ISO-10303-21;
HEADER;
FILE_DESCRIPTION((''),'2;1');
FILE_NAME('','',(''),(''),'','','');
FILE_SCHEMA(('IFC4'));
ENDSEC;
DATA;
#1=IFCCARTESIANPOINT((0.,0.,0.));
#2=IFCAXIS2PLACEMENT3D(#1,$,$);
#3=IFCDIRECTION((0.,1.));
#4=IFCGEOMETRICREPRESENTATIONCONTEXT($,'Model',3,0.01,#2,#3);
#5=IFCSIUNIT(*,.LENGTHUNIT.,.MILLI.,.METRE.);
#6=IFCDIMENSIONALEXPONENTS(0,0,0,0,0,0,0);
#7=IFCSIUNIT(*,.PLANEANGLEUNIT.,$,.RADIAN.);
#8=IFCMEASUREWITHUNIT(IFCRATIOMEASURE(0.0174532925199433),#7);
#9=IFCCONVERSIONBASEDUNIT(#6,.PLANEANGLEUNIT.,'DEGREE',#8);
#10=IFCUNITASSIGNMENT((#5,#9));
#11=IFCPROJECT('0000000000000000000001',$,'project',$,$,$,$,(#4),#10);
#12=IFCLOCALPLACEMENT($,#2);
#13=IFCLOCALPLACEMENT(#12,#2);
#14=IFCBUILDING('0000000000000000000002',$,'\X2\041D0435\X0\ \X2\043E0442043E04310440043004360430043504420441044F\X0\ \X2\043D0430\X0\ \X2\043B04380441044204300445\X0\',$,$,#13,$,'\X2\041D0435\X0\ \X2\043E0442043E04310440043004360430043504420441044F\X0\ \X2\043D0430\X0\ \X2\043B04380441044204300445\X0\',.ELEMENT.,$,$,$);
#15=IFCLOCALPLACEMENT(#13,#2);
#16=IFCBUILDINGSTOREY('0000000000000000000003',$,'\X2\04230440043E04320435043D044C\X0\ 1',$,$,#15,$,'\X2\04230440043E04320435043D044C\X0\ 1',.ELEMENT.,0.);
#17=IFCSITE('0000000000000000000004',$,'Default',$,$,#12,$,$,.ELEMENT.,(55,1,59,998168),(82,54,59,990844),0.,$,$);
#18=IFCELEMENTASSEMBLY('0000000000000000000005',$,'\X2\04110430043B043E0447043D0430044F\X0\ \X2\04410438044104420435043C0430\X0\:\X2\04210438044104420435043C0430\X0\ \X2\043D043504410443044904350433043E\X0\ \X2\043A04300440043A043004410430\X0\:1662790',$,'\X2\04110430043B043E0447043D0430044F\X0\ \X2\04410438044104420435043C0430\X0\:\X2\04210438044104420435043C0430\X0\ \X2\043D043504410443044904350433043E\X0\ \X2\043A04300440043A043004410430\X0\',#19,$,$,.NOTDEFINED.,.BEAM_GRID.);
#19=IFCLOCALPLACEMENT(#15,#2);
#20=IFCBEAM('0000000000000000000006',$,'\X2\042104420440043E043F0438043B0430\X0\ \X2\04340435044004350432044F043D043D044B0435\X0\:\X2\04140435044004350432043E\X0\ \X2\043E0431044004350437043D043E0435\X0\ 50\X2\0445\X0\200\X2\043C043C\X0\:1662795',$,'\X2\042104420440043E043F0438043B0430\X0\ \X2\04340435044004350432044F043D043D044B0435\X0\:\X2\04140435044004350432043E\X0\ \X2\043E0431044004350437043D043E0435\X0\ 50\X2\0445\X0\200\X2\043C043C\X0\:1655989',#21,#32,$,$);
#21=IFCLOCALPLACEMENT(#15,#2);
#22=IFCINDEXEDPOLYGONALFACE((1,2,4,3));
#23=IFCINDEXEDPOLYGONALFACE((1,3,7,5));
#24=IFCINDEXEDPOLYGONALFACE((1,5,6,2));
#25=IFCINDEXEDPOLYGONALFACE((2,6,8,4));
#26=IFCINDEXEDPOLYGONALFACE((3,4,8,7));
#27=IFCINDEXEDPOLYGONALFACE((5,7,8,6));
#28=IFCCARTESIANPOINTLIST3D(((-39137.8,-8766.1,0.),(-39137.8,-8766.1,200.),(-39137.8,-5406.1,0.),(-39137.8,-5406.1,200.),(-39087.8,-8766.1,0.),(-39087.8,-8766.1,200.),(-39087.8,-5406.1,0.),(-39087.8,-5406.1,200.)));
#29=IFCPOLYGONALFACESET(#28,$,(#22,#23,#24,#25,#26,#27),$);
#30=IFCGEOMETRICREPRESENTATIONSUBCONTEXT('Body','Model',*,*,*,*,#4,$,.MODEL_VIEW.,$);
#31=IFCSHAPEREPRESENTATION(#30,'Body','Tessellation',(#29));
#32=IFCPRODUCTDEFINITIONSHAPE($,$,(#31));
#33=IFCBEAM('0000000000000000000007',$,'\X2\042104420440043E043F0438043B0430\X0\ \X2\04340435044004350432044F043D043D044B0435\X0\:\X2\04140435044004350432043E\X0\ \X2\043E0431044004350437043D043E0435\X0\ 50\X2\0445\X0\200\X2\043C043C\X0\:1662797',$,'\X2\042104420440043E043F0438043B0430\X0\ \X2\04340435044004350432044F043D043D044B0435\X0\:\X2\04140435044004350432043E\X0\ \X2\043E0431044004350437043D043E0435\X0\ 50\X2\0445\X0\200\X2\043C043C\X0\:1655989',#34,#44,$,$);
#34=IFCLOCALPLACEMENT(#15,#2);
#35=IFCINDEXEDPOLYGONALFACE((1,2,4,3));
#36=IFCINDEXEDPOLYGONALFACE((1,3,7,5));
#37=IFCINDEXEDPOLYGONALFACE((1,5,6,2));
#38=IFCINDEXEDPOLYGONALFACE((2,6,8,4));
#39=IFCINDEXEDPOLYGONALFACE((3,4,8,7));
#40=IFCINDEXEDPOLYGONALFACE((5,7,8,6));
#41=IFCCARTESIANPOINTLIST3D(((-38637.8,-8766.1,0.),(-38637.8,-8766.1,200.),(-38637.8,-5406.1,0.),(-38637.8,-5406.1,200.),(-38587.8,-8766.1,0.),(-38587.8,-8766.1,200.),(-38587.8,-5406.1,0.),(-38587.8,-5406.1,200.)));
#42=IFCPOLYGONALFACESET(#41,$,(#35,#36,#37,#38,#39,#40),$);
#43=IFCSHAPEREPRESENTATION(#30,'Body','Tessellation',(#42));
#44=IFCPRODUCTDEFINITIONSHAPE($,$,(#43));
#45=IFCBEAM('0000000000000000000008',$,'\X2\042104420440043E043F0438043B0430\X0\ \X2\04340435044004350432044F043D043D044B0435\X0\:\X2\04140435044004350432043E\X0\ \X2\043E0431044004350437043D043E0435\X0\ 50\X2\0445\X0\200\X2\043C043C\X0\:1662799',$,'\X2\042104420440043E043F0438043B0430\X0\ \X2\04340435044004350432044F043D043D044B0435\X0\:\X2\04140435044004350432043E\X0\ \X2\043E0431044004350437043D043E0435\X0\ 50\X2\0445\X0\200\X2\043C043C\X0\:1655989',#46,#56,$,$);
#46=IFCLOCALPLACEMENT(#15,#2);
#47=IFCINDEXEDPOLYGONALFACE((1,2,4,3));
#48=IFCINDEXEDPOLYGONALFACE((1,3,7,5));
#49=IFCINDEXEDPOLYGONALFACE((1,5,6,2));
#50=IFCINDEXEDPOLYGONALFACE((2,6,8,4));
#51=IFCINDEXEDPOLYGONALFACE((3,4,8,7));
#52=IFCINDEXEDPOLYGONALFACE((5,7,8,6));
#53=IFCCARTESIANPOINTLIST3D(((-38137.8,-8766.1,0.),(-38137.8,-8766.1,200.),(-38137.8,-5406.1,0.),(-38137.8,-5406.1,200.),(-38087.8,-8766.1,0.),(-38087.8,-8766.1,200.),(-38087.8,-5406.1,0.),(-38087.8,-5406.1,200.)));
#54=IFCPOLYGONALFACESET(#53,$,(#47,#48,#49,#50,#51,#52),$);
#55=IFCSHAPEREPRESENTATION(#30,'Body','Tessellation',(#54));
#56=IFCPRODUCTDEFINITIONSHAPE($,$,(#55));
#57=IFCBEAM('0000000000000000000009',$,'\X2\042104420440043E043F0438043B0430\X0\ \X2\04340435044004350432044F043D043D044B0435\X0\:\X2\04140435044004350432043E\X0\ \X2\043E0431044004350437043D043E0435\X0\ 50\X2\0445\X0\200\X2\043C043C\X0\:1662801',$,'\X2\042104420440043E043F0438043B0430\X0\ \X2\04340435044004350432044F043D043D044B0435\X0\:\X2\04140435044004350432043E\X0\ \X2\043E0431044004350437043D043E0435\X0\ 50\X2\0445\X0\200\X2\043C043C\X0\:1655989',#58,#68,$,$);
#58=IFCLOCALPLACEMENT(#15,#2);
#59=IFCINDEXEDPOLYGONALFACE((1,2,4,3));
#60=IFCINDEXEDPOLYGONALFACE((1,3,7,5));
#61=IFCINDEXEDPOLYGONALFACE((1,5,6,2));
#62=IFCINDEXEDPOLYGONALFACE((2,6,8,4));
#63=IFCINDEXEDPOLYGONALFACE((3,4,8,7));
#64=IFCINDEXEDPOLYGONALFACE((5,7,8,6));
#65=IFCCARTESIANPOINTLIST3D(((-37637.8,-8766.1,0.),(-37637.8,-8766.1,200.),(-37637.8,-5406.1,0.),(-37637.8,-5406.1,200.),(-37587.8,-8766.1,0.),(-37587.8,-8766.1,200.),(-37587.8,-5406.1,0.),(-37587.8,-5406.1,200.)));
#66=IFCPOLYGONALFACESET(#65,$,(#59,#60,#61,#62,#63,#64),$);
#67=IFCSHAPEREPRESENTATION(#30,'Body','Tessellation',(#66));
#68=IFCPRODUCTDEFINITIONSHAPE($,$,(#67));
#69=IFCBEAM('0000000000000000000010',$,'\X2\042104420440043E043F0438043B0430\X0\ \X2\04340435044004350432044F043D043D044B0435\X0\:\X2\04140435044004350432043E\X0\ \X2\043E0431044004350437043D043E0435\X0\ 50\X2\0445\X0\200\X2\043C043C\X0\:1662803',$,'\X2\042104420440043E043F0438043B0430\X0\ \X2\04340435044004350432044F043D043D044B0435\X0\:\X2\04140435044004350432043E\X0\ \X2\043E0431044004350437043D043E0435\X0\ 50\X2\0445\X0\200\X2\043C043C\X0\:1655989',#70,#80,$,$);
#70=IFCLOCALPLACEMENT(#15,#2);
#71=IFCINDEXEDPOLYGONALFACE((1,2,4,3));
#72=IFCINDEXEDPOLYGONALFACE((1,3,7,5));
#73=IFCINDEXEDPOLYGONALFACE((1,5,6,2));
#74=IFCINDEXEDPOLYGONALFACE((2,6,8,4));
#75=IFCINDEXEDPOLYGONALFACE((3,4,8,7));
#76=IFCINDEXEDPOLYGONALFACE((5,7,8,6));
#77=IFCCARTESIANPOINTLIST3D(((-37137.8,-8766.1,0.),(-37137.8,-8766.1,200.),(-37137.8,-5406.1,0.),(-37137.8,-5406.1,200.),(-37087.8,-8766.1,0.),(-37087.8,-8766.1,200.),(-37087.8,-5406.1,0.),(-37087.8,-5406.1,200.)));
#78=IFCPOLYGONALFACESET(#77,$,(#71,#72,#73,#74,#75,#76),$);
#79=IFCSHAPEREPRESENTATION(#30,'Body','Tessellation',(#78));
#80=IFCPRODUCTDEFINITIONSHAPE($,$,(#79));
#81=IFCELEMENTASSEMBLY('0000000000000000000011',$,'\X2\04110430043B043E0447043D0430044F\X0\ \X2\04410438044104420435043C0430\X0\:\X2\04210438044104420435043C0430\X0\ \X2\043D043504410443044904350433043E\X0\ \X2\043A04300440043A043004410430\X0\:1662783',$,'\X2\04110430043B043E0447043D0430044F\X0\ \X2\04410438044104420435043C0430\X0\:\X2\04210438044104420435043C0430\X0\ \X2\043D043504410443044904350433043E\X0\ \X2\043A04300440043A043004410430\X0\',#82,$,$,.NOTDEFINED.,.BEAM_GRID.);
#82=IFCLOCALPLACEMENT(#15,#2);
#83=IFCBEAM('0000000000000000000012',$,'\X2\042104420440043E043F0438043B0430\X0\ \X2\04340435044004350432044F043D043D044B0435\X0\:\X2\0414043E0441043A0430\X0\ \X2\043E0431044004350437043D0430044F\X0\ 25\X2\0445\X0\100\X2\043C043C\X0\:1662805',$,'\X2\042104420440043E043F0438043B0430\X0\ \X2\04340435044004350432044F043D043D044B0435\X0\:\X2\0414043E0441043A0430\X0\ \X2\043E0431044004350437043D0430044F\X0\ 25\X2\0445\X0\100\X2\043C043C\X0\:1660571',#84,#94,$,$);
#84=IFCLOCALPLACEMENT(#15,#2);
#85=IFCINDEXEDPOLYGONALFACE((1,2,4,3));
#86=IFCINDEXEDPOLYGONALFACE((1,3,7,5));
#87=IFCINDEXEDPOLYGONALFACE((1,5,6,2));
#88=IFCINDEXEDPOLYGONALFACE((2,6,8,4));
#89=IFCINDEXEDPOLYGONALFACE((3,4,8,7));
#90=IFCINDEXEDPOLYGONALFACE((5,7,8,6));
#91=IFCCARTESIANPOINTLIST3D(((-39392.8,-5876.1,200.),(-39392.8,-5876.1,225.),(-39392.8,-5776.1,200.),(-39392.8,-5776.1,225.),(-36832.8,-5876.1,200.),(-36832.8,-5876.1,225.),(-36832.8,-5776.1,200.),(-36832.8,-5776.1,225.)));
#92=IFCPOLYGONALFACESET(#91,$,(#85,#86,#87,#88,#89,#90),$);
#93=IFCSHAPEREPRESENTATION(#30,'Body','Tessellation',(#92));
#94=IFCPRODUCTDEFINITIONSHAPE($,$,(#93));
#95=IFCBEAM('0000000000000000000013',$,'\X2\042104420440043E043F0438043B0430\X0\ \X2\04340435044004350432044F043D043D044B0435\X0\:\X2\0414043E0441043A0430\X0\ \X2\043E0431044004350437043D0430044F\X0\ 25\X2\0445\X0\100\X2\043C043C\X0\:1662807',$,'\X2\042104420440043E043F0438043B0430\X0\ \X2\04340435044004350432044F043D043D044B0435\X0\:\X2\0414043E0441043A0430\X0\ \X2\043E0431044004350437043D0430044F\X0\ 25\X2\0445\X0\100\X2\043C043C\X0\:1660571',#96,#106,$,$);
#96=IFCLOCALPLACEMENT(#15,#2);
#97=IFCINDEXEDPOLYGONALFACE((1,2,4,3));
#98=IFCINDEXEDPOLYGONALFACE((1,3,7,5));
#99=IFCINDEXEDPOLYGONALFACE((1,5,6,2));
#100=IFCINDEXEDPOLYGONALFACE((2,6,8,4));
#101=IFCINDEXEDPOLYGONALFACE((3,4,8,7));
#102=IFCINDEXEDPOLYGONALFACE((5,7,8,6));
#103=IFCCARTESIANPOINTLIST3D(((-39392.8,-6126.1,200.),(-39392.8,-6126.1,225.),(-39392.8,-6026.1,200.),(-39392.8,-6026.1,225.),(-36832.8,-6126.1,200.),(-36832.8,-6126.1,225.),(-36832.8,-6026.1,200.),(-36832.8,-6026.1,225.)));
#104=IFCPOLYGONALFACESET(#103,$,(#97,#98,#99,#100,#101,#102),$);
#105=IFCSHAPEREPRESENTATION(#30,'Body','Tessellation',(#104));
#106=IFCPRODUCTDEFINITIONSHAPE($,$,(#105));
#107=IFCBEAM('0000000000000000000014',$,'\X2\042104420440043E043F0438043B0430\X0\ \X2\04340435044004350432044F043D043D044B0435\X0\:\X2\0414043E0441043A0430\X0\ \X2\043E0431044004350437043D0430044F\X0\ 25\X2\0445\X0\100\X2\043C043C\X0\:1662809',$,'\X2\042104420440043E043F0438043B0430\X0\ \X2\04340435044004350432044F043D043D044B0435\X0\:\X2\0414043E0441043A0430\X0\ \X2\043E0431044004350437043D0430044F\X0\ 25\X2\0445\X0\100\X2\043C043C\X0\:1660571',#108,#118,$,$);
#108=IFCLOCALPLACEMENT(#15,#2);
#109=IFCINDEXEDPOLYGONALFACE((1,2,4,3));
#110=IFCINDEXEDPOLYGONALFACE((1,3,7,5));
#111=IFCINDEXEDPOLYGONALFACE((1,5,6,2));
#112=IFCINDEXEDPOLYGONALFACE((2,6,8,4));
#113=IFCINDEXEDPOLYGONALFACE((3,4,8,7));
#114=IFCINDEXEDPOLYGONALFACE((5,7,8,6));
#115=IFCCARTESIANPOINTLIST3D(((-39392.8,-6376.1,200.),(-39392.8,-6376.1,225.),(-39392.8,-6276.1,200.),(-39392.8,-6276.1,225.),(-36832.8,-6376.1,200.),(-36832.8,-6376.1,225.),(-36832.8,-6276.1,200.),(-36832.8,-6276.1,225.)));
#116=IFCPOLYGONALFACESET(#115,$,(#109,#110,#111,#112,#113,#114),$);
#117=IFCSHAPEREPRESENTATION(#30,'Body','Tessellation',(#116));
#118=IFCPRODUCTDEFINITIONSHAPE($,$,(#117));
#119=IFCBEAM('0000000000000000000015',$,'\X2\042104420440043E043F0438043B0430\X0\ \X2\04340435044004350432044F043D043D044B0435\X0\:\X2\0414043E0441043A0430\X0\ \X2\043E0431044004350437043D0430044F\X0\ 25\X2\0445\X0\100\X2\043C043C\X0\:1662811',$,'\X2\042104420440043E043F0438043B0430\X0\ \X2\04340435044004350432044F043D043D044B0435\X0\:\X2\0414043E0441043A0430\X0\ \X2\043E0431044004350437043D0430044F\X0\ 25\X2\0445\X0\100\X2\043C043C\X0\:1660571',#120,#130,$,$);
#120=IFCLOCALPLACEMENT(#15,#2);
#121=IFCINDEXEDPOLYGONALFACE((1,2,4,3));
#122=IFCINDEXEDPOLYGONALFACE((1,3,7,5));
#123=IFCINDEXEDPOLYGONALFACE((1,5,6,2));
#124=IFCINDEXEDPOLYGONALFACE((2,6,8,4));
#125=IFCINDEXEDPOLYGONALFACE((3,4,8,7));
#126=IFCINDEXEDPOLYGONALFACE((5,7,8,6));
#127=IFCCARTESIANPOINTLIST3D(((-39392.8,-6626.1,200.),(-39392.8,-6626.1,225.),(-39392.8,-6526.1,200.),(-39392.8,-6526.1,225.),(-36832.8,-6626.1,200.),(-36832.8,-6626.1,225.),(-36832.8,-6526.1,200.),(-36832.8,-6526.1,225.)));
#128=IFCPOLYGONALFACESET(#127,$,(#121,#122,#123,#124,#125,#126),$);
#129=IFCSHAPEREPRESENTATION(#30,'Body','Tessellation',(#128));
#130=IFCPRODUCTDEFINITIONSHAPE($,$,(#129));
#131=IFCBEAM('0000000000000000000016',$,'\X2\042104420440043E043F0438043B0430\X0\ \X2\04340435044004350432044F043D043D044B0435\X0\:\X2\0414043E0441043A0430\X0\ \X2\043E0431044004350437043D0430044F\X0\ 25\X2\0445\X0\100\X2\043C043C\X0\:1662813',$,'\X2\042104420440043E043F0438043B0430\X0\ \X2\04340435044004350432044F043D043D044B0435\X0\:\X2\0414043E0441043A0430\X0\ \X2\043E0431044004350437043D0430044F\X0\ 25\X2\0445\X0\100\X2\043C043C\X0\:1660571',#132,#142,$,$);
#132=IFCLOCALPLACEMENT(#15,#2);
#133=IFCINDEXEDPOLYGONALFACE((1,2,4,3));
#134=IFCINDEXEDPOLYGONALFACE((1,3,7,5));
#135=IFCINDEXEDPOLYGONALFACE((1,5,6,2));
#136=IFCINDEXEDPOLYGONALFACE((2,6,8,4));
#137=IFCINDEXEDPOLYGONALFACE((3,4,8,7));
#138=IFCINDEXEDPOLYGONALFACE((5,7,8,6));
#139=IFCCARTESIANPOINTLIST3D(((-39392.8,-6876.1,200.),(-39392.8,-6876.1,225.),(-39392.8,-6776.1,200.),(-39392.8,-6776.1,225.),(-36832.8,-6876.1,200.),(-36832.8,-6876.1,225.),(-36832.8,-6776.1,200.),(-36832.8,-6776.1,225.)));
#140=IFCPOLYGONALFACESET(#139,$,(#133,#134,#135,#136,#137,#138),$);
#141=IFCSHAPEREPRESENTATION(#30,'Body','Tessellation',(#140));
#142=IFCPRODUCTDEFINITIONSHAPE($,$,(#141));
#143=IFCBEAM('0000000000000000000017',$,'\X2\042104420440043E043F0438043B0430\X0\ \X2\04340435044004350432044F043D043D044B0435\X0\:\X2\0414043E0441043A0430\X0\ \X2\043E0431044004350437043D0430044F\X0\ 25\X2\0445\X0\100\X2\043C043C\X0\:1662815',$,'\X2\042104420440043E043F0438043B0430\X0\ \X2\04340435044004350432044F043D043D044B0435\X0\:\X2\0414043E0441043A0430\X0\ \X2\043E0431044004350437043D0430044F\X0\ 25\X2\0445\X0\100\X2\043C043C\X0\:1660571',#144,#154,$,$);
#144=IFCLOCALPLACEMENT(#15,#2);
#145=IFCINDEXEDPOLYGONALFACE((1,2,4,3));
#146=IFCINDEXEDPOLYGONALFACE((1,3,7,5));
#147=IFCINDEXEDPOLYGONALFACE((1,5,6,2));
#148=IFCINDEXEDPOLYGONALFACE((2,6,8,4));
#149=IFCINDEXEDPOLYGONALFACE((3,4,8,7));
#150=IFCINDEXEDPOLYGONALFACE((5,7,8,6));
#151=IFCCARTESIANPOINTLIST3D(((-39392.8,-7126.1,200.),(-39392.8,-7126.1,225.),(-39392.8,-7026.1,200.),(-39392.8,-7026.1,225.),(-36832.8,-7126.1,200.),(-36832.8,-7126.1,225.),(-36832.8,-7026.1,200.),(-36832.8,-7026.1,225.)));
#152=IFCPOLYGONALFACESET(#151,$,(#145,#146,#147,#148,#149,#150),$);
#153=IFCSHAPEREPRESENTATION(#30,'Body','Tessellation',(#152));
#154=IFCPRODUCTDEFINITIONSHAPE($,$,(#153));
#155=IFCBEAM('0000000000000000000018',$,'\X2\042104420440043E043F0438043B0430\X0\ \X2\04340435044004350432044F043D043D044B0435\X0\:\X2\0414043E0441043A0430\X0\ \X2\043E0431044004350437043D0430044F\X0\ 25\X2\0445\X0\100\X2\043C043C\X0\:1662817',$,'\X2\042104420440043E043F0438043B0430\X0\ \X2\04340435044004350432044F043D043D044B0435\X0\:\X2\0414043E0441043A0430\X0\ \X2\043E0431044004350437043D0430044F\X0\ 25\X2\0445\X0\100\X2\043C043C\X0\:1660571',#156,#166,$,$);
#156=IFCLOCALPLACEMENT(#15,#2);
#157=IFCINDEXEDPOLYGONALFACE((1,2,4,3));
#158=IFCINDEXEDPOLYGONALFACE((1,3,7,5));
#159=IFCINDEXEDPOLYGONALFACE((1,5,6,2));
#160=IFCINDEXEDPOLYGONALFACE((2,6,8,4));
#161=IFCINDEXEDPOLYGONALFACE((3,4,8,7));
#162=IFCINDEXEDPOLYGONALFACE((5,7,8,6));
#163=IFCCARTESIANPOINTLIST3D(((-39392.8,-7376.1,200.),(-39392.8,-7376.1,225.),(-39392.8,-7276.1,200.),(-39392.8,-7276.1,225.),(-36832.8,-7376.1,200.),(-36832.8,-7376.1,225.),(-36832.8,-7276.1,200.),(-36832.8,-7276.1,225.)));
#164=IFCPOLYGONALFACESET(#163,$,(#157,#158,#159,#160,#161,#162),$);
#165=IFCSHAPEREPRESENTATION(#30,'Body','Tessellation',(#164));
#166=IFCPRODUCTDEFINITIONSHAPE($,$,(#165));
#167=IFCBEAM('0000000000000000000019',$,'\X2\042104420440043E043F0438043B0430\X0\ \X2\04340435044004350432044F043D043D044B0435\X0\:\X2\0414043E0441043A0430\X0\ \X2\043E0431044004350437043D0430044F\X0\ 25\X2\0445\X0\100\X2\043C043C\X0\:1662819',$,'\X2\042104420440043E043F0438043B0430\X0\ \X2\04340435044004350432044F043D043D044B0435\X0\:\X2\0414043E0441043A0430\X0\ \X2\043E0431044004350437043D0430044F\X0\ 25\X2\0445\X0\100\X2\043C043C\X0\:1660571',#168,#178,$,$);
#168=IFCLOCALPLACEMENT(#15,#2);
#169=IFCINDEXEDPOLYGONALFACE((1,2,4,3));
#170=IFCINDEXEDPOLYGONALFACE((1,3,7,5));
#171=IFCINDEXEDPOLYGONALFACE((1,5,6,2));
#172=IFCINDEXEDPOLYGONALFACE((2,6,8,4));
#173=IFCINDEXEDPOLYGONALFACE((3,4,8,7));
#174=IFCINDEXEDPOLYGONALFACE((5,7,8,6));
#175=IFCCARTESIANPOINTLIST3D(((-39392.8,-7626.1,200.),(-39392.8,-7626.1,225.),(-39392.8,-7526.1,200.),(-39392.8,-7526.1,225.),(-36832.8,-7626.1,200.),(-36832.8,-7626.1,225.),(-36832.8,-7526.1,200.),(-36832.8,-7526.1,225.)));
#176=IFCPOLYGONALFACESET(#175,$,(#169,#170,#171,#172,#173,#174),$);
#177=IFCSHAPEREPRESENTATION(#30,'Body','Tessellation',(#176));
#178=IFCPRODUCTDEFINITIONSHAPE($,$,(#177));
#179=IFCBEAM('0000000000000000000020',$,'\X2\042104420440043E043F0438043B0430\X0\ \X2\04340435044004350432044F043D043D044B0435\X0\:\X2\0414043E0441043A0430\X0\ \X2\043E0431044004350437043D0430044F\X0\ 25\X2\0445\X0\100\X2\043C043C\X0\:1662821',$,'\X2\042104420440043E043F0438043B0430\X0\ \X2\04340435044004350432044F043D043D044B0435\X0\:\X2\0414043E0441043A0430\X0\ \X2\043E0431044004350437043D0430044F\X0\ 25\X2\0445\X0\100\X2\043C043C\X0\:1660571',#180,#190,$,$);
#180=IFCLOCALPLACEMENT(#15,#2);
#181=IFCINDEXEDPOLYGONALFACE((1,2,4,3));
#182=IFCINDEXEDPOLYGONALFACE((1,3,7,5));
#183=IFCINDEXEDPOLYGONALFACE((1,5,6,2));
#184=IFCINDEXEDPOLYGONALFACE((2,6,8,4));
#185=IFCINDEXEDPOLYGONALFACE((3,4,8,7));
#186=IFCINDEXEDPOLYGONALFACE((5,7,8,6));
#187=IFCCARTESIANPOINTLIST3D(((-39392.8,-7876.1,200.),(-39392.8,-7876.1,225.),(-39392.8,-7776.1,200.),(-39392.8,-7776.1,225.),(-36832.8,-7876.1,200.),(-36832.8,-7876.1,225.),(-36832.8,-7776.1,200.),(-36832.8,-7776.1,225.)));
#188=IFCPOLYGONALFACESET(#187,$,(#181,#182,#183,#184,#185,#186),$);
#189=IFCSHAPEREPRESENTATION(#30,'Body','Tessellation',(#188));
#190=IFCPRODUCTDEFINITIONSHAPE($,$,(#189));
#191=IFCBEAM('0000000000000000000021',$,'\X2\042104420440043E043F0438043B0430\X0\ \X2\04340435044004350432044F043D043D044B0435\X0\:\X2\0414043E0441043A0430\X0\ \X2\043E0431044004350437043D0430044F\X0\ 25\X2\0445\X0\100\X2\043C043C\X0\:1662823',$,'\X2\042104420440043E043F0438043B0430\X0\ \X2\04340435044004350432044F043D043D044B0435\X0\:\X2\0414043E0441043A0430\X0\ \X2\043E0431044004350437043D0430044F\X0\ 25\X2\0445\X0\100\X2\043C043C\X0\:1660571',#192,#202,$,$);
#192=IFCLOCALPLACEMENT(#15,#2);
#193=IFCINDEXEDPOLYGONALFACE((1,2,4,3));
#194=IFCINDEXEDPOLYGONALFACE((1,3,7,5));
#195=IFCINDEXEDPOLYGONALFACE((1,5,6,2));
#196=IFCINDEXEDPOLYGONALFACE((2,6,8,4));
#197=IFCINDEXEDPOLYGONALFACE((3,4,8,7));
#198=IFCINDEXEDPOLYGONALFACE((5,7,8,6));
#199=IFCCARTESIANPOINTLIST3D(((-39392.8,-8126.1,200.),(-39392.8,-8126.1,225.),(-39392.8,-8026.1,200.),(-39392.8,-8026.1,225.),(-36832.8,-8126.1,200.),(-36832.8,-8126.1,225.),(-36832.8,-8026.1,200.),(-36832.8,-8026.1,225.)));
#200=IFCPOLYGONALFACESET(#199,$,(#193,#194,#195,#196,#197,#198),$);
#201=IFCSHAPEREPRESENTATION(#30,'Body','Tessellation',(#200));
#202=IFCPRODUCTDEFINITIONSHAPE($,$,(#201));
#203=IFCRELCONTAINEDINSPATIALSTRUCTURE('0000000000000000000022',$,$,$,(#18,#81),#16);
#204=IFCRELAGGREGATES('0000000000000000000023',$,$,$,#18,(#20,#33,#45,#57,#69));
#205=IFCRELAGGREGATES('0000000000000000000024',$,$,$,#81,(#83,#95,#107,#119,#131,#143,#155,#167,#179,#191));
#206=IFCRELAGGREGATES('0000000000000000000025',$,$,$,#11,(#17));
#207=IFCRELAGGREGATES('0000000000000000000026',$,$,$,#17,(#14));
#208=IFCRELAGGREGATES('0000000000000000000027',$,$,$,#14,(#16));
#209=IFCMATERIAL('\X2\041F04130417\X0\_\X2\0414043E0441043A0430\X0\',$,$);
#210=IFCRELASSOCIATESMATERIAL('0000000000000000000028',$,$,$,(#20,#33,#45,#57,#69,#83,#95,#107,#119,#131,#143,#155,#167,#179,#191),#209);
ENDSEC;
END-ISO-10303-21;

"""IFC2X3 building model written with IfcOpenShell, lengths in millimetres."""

from ifc_helpers import new_model, entity, si_unit, converted_unit, direction, frame, frame_2d, origin, place, context, subcontext, project, spatial, rectangle, extrude, material, element, aggregate, save


model = new_model("IFC2X3")

# Units and contexts
model_context = context("Model", 3, precision=0.01, world=origin(), true_north=direction((0.0, 1.0)))
body_context = subcontext(model_context, "Body", "Model", "MODEL_VIEW")
ifc_project = project(units=[si_unit("LENGTHUNIT", "METRE", prefix="MILLI"), converted_unit("PLANEANGLEUNIT", "DEGREE", entity("IfcRatioMeasure", 0.0174532925199433), si_unit("PLANEANGLEUNIT", "RADIAN"), dimensions=[0, 0, 0, 0, 0, 0, 0])], contexts=[model_context])

# Site, building, storey
site_placement = place(None, origin())
site = spatial("IfcSite", under=ifc_project, at=site_placement, Name="Default", CompositionType="ELEMENT", RefLatitude=(55, 1, 59, 998168), RefLongitude=(82, 54, 59, 990844), RefElevation=0.0)
building_placement = place(site_placement, origin())
building = spatial("IfcBuilding", under=site, at=building_placement, Name="Не отображается на листах", LongName="Не отображается на листах", CompositionType="ELEMENT")
storey_placement = place(building_placement, frame((0.0, 0.0, 0.0)))
storey = spatial("IfcBuildingStorey", under=building, at=storey_placement, Name="Уровень 1", LongName="Уровень 1", CompositionType="ELEMENT", Elevation=0.0)

# Element assemblies, beams
assembly_1_placement = place(storey_placement, origin())
assembly_1 = element("IfcElementAssembly", 1, at=assembly_1_placement, inside=storey, Name="Балочная система:Система несущего каркаса:1662790", ObjectType="Балочная система:Система несущего каркаса", AssemblyPlace="NOTDEFINED", PredefinedType="BEAM_GRID")
ifc_material_1 = material(Name="ПГЗ_Доска")
beam_1_placement = place(assembly_1_placement, frame((-39112.8, -8766.1, 0.0), z_axis=(0.0, 0.0, 1.0), x_axis=(0.0, 1.0, 0.0)))
beam_1 = element("IfcBeam", 2, at=beam_1_placement, material=ifc_material_1, Name="Стропила деревянные:Дерево обрезное 50х200мм:1662795", ObjectType="Стропила деревянные:Дерево обрезное 50х200мм:1655989", context=body_context, shape_type="SweptSolid", body=[
    extrude(rectangle(XDim=200.0, YDim=50.0, at=frame_2d((0.0, 0.0), x_axis=(1.0, 0.0))), frame((0.0, 0.0, 100.0), z_axis=(1.0, 0.0, 0.0), x_axis=(0.0, 0.0, -1.0)), (0.0, 0.0, 1.0), 3360.0),
])
beam_2_placement = place(assembly_1_placement, frame((-38612.8, -8766.1, 0.0), z_axis=(0.0, 0.0, 1.0), x_axis=(0.0, 1.0, 0.0)))
beam_2 = element("IfcBeam", 3, at=beam_2_placement, material=ifc_material_1, Name="Стропила деревянные:Дерево обрезное 50х200мм:1662797", ObjectType="Стропила деревянные:Дерево обрезное 50х200мм:1655989", context=body_context, shape_type="SweptSolid", body=[
    extrude(rectangle(XDim=200.0, YDim=50.0, at=frame_2d((0.0, 0.0), x_axis=(1.0, 0.0))), frame((0.0, 0.0, 100.0), z_axis=(1.0, 0.0, 0.0), x_axis=(0.0, 0.0, -1.0)), (0.0, 0.0, 1.0), 3360.0),
])
beam_3_placement = place(assembly_1_placement, frame((-38112.8, -8766.1, 0.0), z_axis=(0.0, 0.0, 1.0), x_axis=(0.0, 1.0, 0.0)))
beam_3 = element("IfcBeam", 4, at=beam_3_placement, material=ifc_material_1, Name="Стропила деревянные:Дерево обрезное 50х200мм:1662799", ObjectType="Стропила деревянные:Дерево обрезное 50х200мм:1655989", context=body_context, shape_type="SweptSolid", body=[
    extrude(rectangle(XDim=200.0, YDim=50.0, at=frame_2d((0.0, 0.0), x_axis=(1.0, 0.0))), frame((0.0, 0.0, 100.0), z_axis=(1.0, 0.0, 0.0), x_axis=(0.0, 0.0, -1.0)), (0.0, 0.0, 1.0), 3360.0),
])
beam_4_placement = place(assembly_1_placement, frame((-37612.8, -8766.1, 0.0), z_axis=(0.0, 0.0, 1.0), x_axis=(0.0, 1.0, 0.0)))
beam_4 = element("IfcBeam", 5, at=beam_4_placement, material=ifc_material_1, Name="Стропила деревянные:Дерево обрезное 50х200мм:1662801", ObjectType="Стропила деревянные:Дерево обрезное 50х200мм:1655989", context=body_context, shape_type="SweptSolid", body=[
    extrude(rectangle(XDim=200.0, YDim=50.0, at=frame_2d((0.0, 0.0), x_axis=(1.0, 0.0))), frame((0.0, 0.0, 100.0), z_axis=(1.0, 0.0, 0.0), x_axis=(0.0, 0.0, -1.0)), (0.0, 0.0, 1.0), 3360.0),
])
beam_5_placement = place(assembly_1_placement, frame((-37112.8, -8766.1, 0.0), z_axis=(0.0, 0.0, 1.0), x_axis=(0.0, 1.0, 0.0)))
beam_5 = element("IfcBeam", 6, at=beam_5_placement, material=ifc_material_1, Name="Стропила деревянные:Дерево обрезное 50х200мм:1662803", ObjectType="Стропила деревянные:Дерево обрезное 50х200мм:1655989", context=body_context, shape_type="SweptSolid", body=[
    extrude(rectangle(XDim=200.0, YDim=50.0, at=frame_2d((0.0, 0.0), x_axis=(1.0, 0.0))), frame((0.0, 0.0, 100.0), z_axis=(1.0, 0.0, 0.0), x_axis=(0.0, 0.0, -1.0)), (0.0, 0.0, 1.0), 3360.0),
])
aggregate(assembly_1, [beam_1, beam_2, beam_3, beam_4, beam_5])
assembly_2_placement = place(storey_placement, origin())
assembly_2 = element("IfcElementAssembly", 7, at=assembly_2_placement, inside=storey, Name="Балочная система:Система несущего каркаса:1662783", ObjectType="Балочная система:Система несущего каркаса", AssemblyPlace="NOTDEFINED", PredefinedType="BEAM_GRID")
beam_6_placement = place(assembly_2_placement, frame((-39392.8, -5826.1, 0.0)))
beam_6 = element("IfcBeam", 8, at=beam_6_placement, material=ifc_material_1, Name="Стропила деревянные:Доска обрезная 25х100мм:1662805", ObjectType="Стропила деревянные:Доска обрезная 25х100мм:1660571", context=body_context, shape_type="SweptSolid", body=[
    extrude(rectangle(XDim=25.0, YDim=100.0, at=frame_2d((0.0, 0.0), x_axis=(1.0, 0.0))), frame((0.0, 0.0, 212.5), z_axis=(1.0, 0.0, 0.0), x_axis=(0.0, 0.0, -1.0)), (0.0, 0.0, 1.0), 2560.0),
])
beam_7_placement = place(assembly_2_placement, frame((-39392.8, -6076.1, 0.0)))
beam_7 = element("IfcBeam", 9, at=beam_7_placement, material=ifc_material_1, Name="Стропила деревянные:Доска обрезная 25х100мм:1662807", ObjectType="Стропила деревянные:Доска обрезная 25х100мм:1660571", context=body_context, shape_type="SweptSolid", body=[
    extrude(rectangle(XDim=25.0, YDim=100.0, at=frame_2d((0.0, 0.0), x_axis=(1.0, 0.0))), frame((0.0, 0.0, 212.5), z_axis=(1.0, 0.0, 0.0), x_axis=(0.0, 0.0, -1.0)), (0.0, 0.0, 1.0), 2560.0),
])
beam_8_placement = place(assembly_2_placement, frame((-39392.8, -6326.1, 0.0)))
beam_8 = element("IfcBeam", 10, at=beam_8_placement, material=ifc_material_1, Name="Стропила деревянные:Доска обрезная 25х100мм:1662809", ObjectType="Стропила деревянные:Доска обрезная 25х100мм:1660571", context=body_context, shape_type="SweptSolid", body=[
    extrude(rectangle(XDim=25.0, YDim=100.0, at=frame_2d((0.0, 0.0), x_axis=(1.0, 0.0))), frame((0.0, 0.0, 212.5), z_axis=(1.0, 0.0, 0.0), x_axis=(0.0, 0.0, -1.0)), (0.0, 0.0, 1.0), 2560.0),
])
beam_9_placement = place(assembly_2_placement, frame((-39392.8, -6576.1, 0.0)))
beam_9 = element("IfcBeam", 11, at=beam_9_placement, material=ifc_material_1, Name="Стропила деревянные:Доска обрезная 25х100мм:1662811", ObjectType="Стропила деревянные:Доска обрезная 25х100мм:1660571", context=body_context, shape_type="SweptSolid", body=[
    extrude(rectangle(XDim=25.0, YDim=100.0, at=frame_2d((0.0, 0.0), x_axis=(1.0, 0.0))), frame((0.0, 0.0, 212.5), z_axis=(1.0, 0.0, 0.0), x_axis=(0.0, 0.0, -1.0)), (0.0, 0.0, 1.0), 2560.0),
])
beam_10_placement = place(assembly_2_placement, frame((-39392.8, -6826.1, 0.0)))
beam_10 = element("IfcBeam", 12, at=beam_10_placement, material=ifc_material_1, Name="Стропила деревянные:Доска обрезная 25х100мм:1662813", ObjectType="Стропила деревянные:Доска обрезная 25х100мм:1660571", context=body_context, shape_type="SweptSolid", body=[
    extrude(rectangle(XDim=25.0, YDim=100.0, at=frame_2d((0.0, 0.0), x_axis=(1.0, 0.0))), frame((0.0, 0.0, 212.5), z_axis=(1.0, 0.0, 0.0), x_axis=(0.0, 0.0, -1.0)), (0.0, 0.0, 1.0), 2560.0),
])
beam_11_placement = place(assembly_2_placement, frame((-39392.8, -7076.1, 0.0)))
beam_11 = element("IfcBeam", 13, at=beam_11_placement, material=ifc_material_1, Name="Стропила деревянные:Доска обрезная 25х100мм:1662815", ObjectType="Стропила деревянные:Доска обрезная 25х100мм:1660571", context=body_context, shape_type="SweptSolid", body=[
    extrude(rectangle(XDim=25.0, YDim=100.0, at=frame_2d((0.0, 0.0), x_axis=(1.0, 0.0))), frame((0.0, 0.0, 212.5), z_axis=(1.0, 0.0, 0.0), x_axis=(0.0, 0.0, -1.0)), (0.0, 0.0, 1.0), 2560.0),
])
beam_12_placement = place(assembly_2_placement, frame((-39392.8, -7326.1, 0.0)))
beam_12 = element("IfcBeam", 14, at=beam_12_placement, material=ifc_material_1, Name="Стропила деревянные:Доска обрезная 25х100мм:1662817", ObjectType="Стропила деревянные:Доска обрезная 25х100мм:1660571", context=body_context, shape_type="SweptSolid", body=[
    extrude(rectangle(XDim=25.0, YDim=100.0, at=frame_2d((0.0, 0.0), x_axis=(1.0, 0.0))), frame((0.0, 0.0, 212.5), z_axis=(1.0, 0.0, 0.0), x_axis=(0.0, 0.0, -1.0)), (0.0, 0.0, 1.0), 2560.0),
])
beam_13_placement = place(assembly_2_placement, frame((-39392.8, -7576.1, 0.0)))
beam_13 = element("IfcBeam", 15, at=beam_13_placement, material=ifc_material_1, Name="Стропила деревянные:Доска обрезная 25х100мм:1662819", ObjectType="Стропила деревянные:Доска обрезная 25х100мм:1660571", context=body_context, shape_type="SweptSolid", body=[
    extrude(rectangle(XDim=25.0, YDim=100.0, at=frame_2d((0.0, 0.0), x_axis=(1.0, 0.0))), frame((0.0, 0.0, 212.5), z_axis=(1.0, 0.0, 0.0), x_axis=(0.0, 0.0, -1.0)), (0.0, 0.0, 1.0), 2560.0),
])
beam_14_placement = place(assembly_2_placement, frame((-39392.8, -7826.1, 0.0)))
beam_14 = element("IfcBeam", 16, at=beam_14_placement, material=ifc_material_1, Name="Стропила деревянные:Доска обрезная 25х100мм:1662821", ObjectType="Стропила деревянные:Доска обрезная 25х100мм:1660571", context=body_context, shape_type="SweptSolid", body=[
    extrude(rectangle(XDim=25.0, YDim=100.0, at=frame_2d((0.0, 0.0), x_axis=(1.0, 0.0))), frame((0.0, 0.0, 212.5), z_axis=(1.0, 0.0, 0.0), x_axis=(0.0, 0.0, -1.0)), (0.0, 0.0, 1.0), 2560.0),
])
beam_15_placement = place(assembly_2_placement, frame((-39392.8, -8076.1, 0.0)))
beam_15 = element("IfcBeam", 17, at=beam_15_placement, material=ifc_material_1, Name="Стропила деревянные:Доска обрезная 25х100мм:1662823", ObjectType="Стропила деревянные:Доска обрезная 25х100мм:1660571", context=body_context, shape_type="SweptSolid", body=[
    extrude(rectangle(XDim=25.0, YDim=100.0, at=frame_2d((0.0, 0.0), x_axis=(1.0, 0.0))), frame((0.0, 0.0, 212.5), z_axis=(1.0, 0.0, 0.0), x_axis=(0.0, 0.0, -1.0)), (0.0, 0.0, 1.0), 2560.0),
])
aggregate(assembly_2, [beam_6, beam_7, beam_8, beam_9, beam_10, beam_11, beam_12, beam_13, beam_14, beam_15])

save(model, "model.ifc")
